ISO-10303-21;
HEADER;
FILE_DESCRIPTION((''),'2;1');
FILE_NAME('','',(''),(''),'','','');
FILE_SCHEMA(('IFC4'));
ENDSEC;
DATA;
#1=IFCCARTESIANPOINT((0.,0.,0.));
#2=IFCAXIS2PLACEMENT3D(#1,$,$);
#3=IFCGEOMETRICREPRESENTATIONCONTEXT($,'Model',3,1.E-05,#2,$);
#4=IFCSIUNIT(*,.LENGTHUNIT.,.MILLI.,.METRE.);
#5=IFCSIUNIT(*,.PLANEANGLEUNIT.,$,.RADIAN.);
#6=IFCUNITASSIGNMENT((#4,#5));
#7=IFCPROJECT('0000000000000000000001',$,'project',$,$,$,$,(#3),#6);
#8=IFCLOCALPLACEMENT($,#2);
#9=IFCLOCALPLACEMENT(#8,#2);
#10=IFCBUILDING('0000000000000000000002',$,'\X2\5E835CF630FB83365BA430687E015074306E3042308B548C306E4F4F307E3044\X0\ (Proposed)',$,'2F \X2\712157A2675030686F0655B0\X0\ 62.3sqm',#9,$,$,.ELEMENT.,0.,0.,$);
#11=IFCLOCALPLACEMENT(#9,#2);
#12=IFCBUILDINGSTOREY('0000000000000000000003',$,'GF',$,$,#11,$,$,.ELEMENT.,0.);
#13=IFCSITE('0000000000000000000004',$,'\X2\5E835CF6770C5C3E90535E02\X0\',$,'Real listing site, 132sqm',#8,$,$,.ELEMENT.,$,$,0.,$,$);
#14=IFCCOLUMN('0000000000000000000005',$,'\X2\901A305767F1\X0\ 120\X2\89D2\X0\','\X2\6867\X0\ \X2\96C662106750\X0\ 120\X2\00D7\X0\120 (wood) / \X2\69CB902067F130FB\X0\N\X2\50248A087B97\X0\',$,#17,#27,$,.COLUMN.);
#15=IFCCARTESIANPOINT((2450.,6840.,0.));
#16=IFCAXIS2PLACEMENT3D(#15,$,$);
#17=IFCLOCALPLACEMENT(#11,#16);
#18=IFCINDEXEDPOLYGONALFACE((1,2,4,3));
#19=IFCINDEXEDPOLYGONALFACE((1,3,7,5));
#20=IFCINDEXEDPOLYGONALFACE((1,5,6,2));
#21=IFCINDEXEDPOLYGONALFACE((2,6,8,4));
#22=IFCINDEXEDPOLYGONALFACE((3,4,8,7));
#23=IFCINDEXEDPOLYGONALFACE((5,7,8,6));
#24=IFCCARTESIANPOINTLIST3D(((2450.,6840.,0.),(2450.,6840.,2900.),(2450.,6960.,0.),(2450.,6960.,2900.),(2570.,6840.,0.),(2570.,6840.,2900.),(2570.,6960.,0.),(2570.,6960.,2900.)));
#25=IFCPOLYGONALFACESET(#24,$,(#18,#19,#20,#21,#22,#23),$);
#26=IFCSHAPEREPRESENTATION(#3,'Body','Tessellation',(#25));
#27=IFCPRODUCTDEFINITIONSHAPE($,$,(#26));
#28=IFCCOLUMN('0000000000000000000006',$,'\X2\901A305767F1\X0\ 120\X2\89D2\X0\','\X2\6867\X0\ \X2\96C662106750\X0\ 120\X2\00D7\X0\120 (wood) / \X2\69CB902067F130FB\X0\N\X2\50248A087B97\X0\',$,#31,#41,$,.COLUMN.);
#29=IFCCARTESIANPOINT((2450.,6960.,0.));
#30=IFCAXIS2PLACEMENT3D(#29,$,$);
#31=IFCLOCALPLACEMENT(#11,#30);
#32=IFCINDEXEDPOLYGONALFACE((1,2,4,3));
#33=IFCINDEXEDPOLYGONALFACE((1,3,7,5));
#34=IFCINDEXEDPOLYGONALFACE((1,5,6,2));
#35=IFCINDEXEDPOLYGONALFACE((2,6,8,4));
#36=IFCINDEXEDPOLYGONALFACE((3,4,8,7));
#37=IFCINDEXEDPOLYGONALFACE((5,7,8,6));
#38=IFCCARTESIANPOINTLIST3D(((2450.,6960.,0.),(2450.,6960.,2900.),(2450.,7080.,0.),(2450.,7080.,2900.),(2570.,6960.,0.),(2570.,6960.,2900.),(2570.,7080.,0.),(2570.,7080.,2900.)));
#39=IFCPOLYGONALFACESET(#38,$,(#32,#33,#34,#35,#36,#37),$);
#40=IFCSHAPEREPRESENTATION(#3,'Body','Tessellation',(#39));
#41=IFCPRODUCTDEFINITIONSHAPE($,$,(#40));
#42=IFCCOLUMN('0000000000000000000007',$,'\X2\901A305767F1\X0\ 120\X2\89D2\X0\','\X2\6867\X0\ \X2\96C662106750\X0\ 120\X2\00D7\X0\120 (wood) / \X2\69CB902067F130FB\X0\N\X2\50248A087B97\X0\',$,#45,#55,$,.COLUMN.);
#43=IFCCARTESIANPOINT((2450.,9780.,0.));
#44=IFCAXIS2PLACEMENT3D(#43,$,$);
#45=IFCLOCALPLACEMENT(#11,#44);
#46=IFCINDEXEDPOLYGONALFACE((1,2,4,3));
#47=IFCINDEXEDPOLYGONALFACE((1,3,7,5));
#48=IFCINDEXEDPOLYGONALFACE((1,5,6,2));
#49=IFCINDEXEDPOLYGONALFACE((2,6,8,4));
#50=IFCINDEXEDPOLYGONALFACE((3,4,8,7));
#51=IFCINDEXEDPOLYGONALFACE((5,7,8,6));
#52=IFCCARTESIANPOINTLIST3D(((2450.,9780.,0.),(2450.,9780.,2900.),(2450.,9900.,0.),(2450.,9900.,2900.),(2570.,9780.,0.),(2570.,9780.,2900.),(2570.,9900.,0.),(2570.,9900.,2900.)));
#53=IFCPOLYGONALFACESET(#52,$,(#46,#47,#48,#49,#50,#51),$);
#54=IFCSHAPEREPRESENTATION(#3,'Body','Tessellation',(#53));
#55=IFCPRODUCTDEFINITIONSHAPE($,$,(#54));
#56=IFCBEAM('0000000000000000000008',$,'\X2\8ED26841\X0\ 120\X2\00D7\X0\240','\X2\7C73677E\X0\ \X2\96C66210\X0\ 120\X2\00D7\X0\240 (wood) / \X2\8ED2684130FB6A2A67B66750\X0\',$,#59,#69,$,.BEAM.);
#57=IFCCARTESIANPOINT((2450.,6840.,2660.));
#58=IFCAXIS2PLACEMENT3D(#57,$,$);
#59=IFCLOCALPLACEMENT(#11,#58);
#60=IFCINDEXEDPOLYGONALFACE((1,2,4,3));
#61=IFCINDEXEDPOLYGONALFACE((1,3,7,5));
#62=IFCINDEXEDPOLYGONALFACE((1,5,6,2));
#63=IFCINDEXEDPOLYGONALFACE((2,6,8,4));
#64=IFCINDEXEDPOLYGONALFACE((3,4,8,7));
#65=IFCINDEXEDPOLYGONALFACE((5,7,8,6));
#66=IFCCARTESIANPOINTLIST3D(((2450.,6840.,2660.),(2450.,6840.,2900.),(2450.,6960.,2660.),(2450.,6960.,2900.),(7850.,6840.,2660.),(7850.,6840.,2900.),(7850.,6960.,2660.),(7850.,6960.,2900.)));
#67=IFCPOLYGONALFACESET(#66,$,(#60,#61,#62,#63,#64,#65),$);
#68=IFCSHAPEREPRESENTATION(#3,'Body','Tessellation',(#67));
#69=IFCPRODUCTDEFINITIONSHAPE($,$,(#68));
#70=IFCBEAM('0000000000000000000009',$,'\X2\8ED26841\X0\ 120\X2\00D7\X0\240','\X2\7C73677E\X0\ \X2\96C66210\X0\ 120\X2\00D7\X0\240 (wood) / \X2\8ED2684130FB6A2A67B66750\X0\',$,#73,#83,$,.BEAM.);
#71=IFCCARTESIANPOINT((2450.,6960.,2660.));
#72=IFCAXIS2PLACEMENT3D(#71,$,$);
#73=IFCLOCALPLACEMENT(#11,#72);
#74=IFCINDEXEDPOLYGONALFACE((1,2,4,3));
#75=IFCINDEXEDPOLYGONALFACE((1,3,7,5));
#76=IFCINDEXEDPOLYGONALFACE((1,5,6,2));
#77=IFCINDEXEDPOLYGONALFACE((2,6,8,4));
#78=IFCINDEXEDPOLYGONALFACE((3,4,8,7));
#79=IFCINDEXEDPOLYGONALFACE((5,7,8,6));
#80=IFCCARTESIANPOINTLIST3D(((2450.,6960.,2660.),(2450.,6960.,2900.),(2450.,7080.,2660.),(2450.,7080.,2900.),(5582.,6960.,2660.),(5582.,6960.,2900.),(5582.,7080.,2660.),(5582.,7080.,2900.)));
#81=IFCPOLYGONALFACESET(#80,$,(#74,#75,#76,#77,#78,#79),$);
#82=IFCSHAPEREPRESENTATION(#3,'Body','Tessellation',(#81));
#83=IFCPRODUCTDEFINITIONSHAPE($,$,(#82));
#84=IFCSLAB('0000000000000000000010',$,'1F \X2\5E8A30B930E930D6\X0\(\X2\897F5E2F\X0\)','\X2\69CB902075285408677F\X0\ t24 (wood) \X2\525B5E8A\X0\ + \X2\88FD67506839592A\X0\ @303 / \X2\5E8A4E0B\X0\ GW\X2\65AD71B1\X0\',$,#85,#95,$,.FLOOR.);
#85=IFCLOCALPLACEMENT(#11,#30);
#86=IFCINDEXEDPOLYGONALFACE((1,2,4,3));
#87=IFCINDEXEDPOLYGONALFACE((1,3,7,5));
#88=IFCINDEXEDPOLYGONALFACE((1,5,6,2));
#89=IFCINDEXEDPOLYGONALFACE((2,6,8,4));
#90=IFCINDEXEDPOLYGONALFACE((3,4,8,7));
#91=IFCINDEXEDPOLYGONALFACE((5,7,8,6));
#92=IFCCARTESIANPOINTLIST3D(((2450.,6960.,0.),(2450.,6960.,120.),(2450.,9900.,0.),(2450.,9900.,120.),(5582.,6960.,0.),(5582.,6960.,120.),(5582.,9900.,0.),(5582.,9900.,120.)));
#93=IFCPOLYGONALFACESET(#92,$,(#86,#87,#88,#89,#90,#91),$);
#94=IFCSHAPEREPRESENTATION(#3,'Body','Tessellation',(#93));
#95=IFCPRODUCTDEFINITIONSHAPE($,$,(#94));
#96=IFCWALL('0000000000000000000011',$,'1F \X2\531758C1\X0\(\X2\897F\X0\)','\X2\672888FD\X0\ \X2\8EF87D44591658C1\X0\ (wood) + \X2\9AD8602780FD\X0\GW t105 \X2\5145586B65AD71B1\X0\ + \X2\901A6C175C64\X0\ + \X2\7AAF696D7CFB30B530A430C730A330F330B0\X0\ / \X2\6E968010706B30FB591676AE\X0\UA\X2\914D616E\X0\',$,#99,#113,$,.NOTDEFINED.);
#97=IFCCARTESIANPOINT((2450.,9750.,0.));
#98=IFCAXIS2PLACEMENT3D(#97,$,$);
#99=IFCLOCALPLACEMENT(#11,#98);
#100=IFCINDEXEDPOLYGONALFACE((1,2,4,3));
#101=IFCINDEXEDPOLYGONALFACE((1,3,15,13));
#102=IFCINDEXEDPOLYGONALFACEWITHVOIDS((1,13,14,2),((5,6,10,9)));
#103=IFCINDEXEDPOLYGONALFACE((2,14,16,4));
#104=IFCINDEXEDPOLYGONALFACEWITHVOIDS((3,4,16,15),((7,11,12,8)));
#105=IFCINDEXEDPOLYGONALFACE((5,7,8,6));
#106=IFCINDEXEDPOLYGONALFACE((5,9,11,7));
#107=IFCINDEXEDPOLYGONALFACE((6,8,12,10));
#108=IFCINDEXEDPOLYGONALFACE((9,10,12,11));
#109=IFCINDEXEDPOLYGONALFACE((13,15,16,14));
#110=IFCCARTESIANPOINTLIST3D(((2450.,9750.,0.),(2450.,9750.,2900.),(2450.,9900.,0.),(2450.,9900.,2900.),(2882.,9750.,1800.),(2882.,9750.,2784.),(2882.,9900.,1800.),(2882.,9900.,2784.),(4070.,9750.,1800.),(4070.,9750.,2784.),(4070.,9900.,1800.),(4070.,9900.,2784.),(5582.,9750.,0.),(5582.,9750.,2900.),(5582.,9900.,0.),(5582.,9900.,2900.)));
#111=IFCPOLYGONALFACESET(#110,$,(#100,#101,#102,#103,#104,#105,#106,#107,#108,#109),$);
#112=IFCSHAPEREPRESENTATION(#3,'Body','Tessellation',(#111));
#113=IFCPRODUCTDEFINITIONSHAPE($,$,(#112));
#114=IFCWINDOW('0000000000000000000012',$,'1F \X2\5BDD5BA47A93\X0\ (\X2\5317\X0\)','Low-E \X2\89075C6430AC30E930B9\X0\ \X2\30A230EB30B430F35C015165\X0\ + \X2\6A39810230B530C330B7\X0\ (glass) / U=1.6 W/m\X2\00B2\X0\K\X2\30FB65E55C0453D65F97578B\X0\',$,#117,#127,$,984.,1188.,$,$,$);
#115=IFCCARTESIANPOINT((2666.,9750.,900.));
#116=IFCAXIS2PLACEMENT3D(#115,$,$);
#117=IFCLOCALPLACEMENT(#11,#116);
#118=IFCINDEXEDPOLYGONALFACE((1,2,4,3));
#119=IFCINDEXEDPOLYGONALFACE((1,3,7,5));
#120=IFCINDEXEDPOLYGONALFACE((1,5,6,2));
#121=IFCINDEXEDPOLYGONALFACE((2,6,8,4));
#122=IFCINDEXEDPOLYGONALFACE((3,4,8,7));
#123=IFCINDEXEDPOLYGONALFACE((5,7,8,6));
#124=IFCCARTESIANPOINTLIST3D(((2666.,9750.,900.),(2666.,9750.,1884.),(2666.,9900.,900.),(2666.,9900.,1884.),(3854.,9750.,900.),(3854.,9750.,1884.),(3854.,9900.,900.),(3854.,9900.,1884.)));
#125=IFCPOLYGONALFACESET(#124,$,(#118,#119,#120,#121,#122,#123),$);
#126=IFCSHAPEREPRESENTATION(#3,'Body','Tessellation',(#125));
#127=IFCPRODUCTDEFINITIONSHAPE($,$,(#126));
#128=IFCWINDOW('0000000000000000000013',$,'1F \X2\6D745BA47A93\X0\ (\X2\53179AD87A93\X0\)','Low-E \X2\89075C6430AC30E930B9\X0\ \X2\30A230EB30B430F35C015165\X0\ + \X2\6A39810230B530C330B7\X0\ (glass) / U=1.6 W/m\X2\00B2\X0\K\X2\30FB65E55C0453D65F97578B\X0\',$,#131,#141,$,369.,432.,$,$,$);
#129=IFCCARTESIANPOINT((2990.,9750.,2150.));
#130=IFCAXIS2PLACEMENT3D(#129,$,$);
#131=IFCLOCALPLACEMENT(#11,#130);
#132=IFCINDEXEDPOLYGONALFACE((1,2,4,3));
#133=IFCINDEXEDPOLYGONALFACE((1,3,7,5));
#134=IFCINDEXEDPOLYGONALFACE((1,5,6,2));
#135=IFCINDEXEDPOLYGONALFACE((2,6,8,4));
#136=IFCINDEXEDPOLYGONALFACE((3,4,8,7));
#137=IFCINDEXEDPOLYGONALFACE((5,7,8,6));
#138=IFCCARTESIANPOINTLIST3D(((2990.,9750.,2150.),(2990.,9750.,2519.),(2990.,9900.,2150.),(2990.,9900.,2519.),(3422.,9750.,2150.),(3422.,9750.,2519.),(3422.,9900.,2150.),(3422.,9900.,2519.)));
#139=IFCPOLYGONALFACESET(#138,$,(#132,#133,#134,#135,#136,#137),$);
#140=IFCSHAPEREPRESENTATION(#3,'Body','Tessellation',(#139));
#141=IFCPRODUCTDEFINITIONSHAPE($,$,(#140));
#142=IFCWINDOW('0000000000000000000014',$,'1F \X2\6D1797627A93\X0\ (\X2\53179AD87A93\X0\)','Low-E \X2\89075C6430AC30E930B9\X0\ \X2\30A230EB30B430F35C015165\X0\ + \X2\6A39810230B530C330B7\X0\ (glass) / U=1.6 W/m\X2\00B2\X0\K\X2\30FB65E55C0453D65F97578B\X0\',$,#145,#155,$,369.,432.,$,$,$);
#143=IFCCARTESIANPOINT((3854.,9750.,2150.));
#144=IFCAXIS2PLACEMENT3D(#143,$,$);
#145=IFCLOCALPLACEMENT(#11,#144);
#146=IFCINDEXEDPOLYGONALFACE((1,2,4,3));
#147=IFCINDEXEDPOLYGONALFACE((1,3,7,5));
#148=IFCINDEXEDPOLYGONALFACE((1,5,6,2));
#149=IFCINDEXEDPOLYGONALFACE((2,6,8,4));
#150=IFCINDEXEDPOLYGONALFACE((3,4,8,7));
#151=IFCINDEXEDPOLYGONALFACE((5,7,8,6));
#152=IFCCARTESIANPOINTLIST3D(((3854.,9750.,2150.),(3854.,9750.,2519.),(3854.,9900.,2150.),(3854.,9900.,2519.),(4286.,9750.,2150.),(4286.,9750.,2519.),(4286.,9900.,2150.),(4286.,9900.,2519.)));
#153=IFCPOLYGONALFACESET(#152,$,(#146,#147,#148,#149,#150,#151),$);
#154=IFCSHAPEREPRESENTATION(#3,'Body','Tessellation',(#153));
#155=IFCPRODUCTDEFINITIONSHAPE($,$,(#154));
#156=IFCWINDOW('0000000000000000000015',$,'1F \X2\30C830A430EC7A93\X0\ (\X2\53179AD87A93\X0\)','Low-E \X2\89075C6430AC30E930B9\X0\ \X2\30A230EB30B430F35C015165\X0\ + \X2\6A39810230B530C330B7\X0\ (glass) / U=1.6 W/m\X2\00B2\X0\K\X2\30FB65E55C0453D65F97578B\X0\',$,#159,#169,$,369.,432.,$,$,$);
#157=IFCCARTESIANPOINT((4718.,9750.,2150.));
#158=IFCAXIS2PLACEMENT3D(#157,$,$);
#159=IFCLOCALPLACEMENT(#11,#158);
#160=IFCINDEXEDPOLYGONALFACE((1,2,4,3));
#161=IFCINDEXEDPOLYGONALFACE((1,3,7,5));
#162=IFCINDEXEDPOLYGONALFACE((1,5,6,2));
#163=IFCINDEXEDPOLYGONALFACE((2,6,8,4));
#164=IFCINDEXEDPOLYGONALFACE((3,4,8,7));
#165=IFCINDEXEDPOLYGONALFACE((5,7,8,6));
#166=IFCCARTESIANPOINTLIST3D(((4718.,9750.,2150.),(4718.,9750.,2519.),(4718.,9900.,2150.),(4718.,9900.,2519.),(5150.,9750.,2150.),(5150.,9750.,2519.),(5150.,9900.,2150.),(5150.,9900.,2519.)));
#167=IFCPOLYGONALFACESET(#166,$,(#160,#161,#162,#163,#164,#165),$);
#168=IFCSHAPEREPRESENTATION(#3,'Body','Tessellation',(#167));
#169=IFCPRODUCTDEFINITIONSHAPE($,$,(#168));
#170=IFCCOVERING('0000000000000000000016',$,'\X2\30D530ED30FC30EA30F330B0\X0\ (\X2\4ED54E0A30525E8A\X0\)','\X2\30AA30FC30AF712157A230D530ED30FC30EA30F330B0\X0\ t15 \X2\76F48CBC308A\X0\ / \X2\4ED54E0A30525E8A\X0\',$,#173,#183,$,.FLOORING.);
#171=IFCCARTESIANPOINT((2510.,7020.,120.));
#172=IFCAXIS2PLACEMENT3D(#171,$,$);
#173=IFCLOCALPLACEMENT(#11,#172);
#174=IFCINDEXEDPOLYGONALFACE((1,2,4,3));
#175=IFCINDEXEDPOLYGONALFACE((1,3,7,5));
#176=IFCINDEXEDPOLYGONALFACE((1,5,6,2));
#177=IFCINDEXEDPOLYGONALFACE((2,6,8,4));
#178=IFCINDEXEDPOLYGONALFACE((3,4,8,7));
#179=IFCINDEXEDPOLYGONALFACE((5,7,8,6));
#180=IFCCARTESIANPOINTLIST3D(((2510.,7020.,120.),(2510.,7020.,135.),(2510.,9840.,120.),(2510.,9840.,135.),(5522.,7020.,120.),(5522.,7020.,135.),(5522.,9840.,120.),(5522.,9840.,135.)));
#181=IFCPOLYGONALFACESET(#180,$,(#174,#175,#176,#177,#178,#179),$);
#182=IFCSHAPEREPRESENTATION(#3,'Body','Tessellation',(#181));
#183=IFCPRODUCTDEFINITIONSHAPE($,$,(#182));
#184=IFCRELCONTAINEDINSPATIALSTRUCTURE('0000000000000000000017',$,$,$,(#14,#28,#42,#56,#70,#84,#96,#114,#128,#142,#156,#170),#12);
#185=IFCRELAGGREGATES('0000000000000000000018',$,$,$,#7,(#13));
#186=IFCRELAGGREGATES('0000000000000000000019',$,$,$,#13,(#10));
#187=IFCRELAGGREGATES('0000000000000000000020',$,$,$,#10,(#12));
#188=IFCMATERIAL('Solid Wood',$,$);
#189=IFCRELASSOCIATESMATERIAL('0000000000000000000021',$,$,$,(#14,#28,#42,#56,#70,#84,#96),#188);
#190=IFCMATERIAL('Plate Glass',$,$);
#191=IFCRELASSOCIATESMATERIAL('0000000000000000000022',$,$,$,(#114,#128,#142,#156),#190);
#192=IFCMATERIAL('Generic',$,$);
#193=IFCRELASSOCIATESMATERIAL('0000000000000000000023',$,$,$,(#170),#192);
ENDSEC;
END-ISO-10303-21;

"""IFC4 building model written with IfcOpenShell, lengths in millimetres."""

from ifc_helpers import new_model, si_unit, frame, frame_2d, origin, place, context, project, spatial, rectangle, extrude, material, element, fill, save


model = new_model("IFC4")

# Units and contexts
model_context = context("Model", 3, precision=1e-05, world=origin())
ifc_project = project(units=[si_unit("LENGTHUNIT", "METRE", prefix="MILLI"), si_unit("PLANEANGLEUNIT", "RADIAN")], contexts=[model_context])

# Site, building, storey
site_placement = place(None, origin())
site = spatial("IfcSite", under=ifc_project, at=site_placement, Name="広島県尾道市", ObjectType="Real listing site, 132sqm", CompositionType="ELEMENT", RefElevation=0.0)
building_placement = place(site_placement, origin())
building = spatial("IfcBuilding", under=site, at=building_placement, Name="広島・茶室と縁側のある和の住まい (Proposed)", ObjectType="2F 無垢材と漆喰 62.3sqm", CompositionType="ELEMENT", ElevationOfRefHeight=0.0, ElevationOfTerrain=0.0)
storey_placement = place(building_placement, origin())
storey = spatial("IfcBuildingStorey", under=building, at=storey_placement, Name="GF", CompositionType="ELEMENT", Elevation=0.0)

# Columns
ifc_material_1 = material(Name="Solid Wood")
column_1_placement = place(storey_placement, frame((2450.0, 6840.0, 0.0)))
element("IfcColumn", 1, at=column_1_placement, inside=storey, material=ifc_material_1, Name="通し柱 120角", Description="桧 集成材 120×120 (wood) / 構造柱・N値計算", PredefinedType="COLUMN", context=model_context, shape_type="SweptSolid", body=[
    extrude(rectangle(XDim=120.0, YDim=120.0, at=frame_2d((60.0, 60.0))), frame((2450.0, 6840.0, 0.0)), (0.0, 0.0, 1.0), 2900.0),
])
column_2_placement = place(storey_placement, frame((2450.0, 6960.0, 0.0)))
element("IfcColumn", 2, at=column_2_placement, inside=storey, material=ifc_material_1, Name="通し柱 120角", Description="桧 集成材 120×120 (wood) / 構造柱・N値計算", PredefinedType="COLUMN", context=model_context, shape_type="SweptSolid", body=[
    extrude(rectangle(XDim=120.0, YDim=120.0, at=frame_2d((60.0, 60.0))), frame((2450.0, 6960.0, 0.0)), (0.0, 0.0, 1.0), 2900.0),
])
column_3_placement = place(storey_placement, frame((2450.0, 9780.0, 0.0)))
element("IfcColumn", 3, at=column_3_placement, inside=storey, material=ifc_material_1, Name="通し柱 120角", Description="桧 集成材 120×120 (wood) / 構造柱・N値計算", PredefinedType="COLUMN", context=model_context, shape_type="SweptSolid", body=[
    extrude(rectangle(XDim=120.0, YDim=120.0, at=frame_2d((60.0, 60.0))), frame((2450.0, 9780.0, 0.0)), (0.0, 0.0, 1.0), 2900.0),
])

# Beams
beam_1_placement = place(storey_placement, frame((2450.0, 6840.0, 2660.0)))
element("IfcBeam", 4, at=beam_1_placement, inside=storey, material=ifc_material_1, Name="軒桁 120×240", Description="米松 集成 120×240 (wood) / 軒桁・横架材", PredefinedType="BEAM", context=model_context, shape_type="SweptSolid", body=[
    extrude(rectangle(XDim=5400.0, YDim=120.0, at=frame_2d((2700.0, 60.0))), frame((2450.0, 6840.0, 2660.0)), (0.0, 0.0, 1.0), 240.0),
])
beam_2_placement = place(storey_placement, frame((2450.0, 6960.0, 2660.0)))
element("IfcBeam", 5, at=beam_2_placement, inside=storey, material=ifc_material_1, Name="軒桁 120×240", Description="米松 集成 120×240 (wood) / 軒桁・横架材", PredefinedType="BEAM", context=model_context, shape_type="SweptSolid", body=[
    extrude(rectangle(XDim=3132.0, YDim=120.0, at=frame_2d((1566.0, 60.0))), frame((2450.0, 6960.0, 2660.0)), (0.0, 0.0, 1.0), 240.0),
])

# Slab
slab_placement = place(storey_placement, frame((2450.0, 6960.0, 0.0)))
element("IfcSlab", 6, at=slab_placement, inside=storey, material=ifc_material_1, Name="1F 床スラブ(西帯)", Description="構造用合板 t24 (wood) 剛床 + 製材根太 @303 / 床下 GW断熱", PredefinedType="FLOOR", context=model_context, shape_type="SweptSolid", body=[
    extrude(rectangle(XDim=3132.0, YDim=2940.0, at=frame_2d((1566.0, 1470.0))), frame((2450.0, 6960.0, 0.0)), (0.0, 0.0, 1.0), 120.0),
])

# Wall, openings, windows
wall_1_placement = place(storey_placement, frame((2450.0, 9750.0, 0.0)))
wall_1 = element("IfcWall", 7, at=wall_1_placement, inside=storey, material=ifc_material_1, Name="1F 北壁(西)", Description="木製 軸組外壁 (wood) + 高性能GW t105 充填断熱 + 通気層 + 窯業系サイディング / 準耐火・外皮UA配慮", PredefinedType="NOTDEFINED", context=model_context, shape_type="SweptSolid", body=[
    extrude(rectangle(XDim=3132.0, YDim=150.0, at=frame_2d((1566.0, 75.0))), frame((2450.0, 9750.0, 0.0)), (0.0, 0.0, 1.0), 2900.0),
])
opening_1_placement = place(storey_placement, frame((2666.0, 9750.0, 900.0)))
opening_1 = element("IfcOpeningElement", 8, at=opening_1_placement, cuts=wall_1, PredefinedType="NOTDEFINED", context=model_context, shape_type="SweptSolid", body=[
    extrude(rectangle(XDim=1188.0, YDim=150.0, at=frame_2d((594.0, 75.0))), frame((2666.0, 9750.0, 900.0)), (0.0, 0.0, 1.0), 984.0),
])
opening_2_placement = place(storey_placement, frame((2990.0, 9750.0, 2150.0)))
opening_2 = element("IfcOpeningElement", 9, at=opening_2_placement, cuts=wall_1, PredefinedType="NOTDEFINED", context=model_context, shape_type="SweptSolid", body=[
    extrude(rectangle(XDim=432.0, YDim=150.0, at=frame_2d((216.0, 75.0))), frame((2990.0, 9750.0, 2150.0)), (0.0, 0.0, 1.0), 369.0),
])
opening_3_placement = place(storey_placement, frame((3854.0, 9750.0, 2150.0)))
opening_3 = element("IfcOpeningElement", 10, at=opening_3_placement, cuts=wall_1, PredefinedType="NOTDEFINED", context=model_context, shape_type="SweptSolid", body=[
    extrude(rectangle(XDim=432.0, YDim=150.0, at=frame_2d((216.0, 75.0))), frame((3854.0, 9750.0, 2150.0)), (0.0, 0.0, 1.0), 369.0),
])
opening_4_placement = place(storey_placement, frame((4718.0, 9750.0, 2150.0)))
opening_4 = element("IfcOpeningElement", 11, at=opening_4_placement, cuts=wall_1, PredefinedType="NOTDEFINED", context=model_context, shape_type="SweptSolid", body=[
    extrude(rectangle(XDim=432.0, YDim=150.0, at=frame_2d((216.0, 75.0))), frame((4718.0, 9750.0, 2150.0)), (0.0, 0.0, 1.0), 369.0),
])
ifc_material_2 = material(Name="Plate Glass")
window_1_placement = place(storey_placement, frame((2666.0, 9750.0, 900.0)))
window_1 = element("IfcWindow", 12, at=window_1_placement, inside=storey, material=ifc_material_2, Name="1F 寝室窓 (北)", Description="Low-E 複層ガラス アルゴン封入 + 樹脂サッシ (glass) / U=1.6 W/m²K・日射取得型", OverallHeight=984.0, OverallWidth=1188.0, context=model_context, shape_type="SweptSolid", body=[
    extrude(rectangle(XDim=1188.0, YDim=150.0, at=frame_2d((594.0, 75.0))), frame((2666.0, 9750.0, 900.0)), (0.0, 0.0, 1.0), 984.0),
])
fill(opening_1, window_1)
window_2_placement = place(storey_placement, frame((2990.0, 9750.0, 2150.0)))
window_2 = element("IfcWindow", 13, at=window_2_placement, inside=storey, material=ifc_material_2, Name="1F 浴室窓 (北高窓)", Description="Low-E 複層ガラス アルゴン封入 + 樹脂サッシ (glass) / U=1.6 W/m²K・日射取得型", OverallHeight=369.0, OverallWidth=432.0, context=model_context, shape_type="SweptSolid", body=[
    extrude(rectangle(XDim=432.0, YDim=150.0, at=frame_2d((216.0, 75.0))), frame((2990.0, 9750.0, 2150.0)), (0.0, 0.0, 1.0), 369.0),
])
fill(opening_2, window_2)
window_3_placement = place(storey_placement, frame((3854.0, 9750.0, 2150.0)))
window_3 = element("IfcWindow", 14, at=window_3_placement, inside=storey, material=ifc_material_2, Name="1F 洗面窓 (北高窓)", Description="Low-E 複層ガラス アルゴン封入 + 樹脂サッシ (glass) / U=1.6 W/m²K・日射取得型", OverallHeight=369.0, OverallWidth=432.0, context=model_context, shape_type="SweptSolid", body=[
    extrude(rectangle(XDim=432.0, YDim=150.0, at=frame_2d((216.0, 75.0))), frame((3854.0, 9750.0, 2150.0)), (0.0, 0.0, 1.0), 369.0),
])
fill(opening_3, window_3)
window_4_placement = place(storey_placement, frame((4718.0, 9750.0, 2150.0)))
window_4 = element("IfcWindow", 15, at=window_4_placement, inside=storey, material=ifc_material_2, Name="1F トイレ窓 (北高窓)", Description="Low-E 複層ガラス アルゴン封入 + 樹脂サッシ (glass) / U=1.6 W/m²K・日射取得型", OverallHeight=369.0, OverallWidth=432.0, context=model_context, shape_type="SweptSolid", body=[
    extrude(rectangle(XDim=432.0, YDim=150.0, at=frame_2d((216.0, 75.0))), frame((4718.0, 9750.0, 2150.0)), (0.0, 0.0, 1.0), 369.0),
])
fill(opening_4, window_4)

# Covering
ifc_material_3 = material(Name="Generic")
covering_placement = place(storey_placement, frame((2510.0, 7020.0, 120.0)))
element("IfcCovering", 16, at=covering_placement, inside=storey, material=ifc_material_3, Name="フローリング (仕上げ床)", Description="オーク無垢フローリング t15 直貼り / 仕上げ床", PredefinedType="FLOORING", context=model_context, shape_type="SweptSolid", body=[
    extrude(rectangle(XDim=3012.0, YDim=2820.0, at=frame_2d((1506.0, 1410.0))), frame((2510.0, 7020.0, 120.0)), (0.0, 0.0, 1.0), 15.0),
])

save(model, "model.ifc")
